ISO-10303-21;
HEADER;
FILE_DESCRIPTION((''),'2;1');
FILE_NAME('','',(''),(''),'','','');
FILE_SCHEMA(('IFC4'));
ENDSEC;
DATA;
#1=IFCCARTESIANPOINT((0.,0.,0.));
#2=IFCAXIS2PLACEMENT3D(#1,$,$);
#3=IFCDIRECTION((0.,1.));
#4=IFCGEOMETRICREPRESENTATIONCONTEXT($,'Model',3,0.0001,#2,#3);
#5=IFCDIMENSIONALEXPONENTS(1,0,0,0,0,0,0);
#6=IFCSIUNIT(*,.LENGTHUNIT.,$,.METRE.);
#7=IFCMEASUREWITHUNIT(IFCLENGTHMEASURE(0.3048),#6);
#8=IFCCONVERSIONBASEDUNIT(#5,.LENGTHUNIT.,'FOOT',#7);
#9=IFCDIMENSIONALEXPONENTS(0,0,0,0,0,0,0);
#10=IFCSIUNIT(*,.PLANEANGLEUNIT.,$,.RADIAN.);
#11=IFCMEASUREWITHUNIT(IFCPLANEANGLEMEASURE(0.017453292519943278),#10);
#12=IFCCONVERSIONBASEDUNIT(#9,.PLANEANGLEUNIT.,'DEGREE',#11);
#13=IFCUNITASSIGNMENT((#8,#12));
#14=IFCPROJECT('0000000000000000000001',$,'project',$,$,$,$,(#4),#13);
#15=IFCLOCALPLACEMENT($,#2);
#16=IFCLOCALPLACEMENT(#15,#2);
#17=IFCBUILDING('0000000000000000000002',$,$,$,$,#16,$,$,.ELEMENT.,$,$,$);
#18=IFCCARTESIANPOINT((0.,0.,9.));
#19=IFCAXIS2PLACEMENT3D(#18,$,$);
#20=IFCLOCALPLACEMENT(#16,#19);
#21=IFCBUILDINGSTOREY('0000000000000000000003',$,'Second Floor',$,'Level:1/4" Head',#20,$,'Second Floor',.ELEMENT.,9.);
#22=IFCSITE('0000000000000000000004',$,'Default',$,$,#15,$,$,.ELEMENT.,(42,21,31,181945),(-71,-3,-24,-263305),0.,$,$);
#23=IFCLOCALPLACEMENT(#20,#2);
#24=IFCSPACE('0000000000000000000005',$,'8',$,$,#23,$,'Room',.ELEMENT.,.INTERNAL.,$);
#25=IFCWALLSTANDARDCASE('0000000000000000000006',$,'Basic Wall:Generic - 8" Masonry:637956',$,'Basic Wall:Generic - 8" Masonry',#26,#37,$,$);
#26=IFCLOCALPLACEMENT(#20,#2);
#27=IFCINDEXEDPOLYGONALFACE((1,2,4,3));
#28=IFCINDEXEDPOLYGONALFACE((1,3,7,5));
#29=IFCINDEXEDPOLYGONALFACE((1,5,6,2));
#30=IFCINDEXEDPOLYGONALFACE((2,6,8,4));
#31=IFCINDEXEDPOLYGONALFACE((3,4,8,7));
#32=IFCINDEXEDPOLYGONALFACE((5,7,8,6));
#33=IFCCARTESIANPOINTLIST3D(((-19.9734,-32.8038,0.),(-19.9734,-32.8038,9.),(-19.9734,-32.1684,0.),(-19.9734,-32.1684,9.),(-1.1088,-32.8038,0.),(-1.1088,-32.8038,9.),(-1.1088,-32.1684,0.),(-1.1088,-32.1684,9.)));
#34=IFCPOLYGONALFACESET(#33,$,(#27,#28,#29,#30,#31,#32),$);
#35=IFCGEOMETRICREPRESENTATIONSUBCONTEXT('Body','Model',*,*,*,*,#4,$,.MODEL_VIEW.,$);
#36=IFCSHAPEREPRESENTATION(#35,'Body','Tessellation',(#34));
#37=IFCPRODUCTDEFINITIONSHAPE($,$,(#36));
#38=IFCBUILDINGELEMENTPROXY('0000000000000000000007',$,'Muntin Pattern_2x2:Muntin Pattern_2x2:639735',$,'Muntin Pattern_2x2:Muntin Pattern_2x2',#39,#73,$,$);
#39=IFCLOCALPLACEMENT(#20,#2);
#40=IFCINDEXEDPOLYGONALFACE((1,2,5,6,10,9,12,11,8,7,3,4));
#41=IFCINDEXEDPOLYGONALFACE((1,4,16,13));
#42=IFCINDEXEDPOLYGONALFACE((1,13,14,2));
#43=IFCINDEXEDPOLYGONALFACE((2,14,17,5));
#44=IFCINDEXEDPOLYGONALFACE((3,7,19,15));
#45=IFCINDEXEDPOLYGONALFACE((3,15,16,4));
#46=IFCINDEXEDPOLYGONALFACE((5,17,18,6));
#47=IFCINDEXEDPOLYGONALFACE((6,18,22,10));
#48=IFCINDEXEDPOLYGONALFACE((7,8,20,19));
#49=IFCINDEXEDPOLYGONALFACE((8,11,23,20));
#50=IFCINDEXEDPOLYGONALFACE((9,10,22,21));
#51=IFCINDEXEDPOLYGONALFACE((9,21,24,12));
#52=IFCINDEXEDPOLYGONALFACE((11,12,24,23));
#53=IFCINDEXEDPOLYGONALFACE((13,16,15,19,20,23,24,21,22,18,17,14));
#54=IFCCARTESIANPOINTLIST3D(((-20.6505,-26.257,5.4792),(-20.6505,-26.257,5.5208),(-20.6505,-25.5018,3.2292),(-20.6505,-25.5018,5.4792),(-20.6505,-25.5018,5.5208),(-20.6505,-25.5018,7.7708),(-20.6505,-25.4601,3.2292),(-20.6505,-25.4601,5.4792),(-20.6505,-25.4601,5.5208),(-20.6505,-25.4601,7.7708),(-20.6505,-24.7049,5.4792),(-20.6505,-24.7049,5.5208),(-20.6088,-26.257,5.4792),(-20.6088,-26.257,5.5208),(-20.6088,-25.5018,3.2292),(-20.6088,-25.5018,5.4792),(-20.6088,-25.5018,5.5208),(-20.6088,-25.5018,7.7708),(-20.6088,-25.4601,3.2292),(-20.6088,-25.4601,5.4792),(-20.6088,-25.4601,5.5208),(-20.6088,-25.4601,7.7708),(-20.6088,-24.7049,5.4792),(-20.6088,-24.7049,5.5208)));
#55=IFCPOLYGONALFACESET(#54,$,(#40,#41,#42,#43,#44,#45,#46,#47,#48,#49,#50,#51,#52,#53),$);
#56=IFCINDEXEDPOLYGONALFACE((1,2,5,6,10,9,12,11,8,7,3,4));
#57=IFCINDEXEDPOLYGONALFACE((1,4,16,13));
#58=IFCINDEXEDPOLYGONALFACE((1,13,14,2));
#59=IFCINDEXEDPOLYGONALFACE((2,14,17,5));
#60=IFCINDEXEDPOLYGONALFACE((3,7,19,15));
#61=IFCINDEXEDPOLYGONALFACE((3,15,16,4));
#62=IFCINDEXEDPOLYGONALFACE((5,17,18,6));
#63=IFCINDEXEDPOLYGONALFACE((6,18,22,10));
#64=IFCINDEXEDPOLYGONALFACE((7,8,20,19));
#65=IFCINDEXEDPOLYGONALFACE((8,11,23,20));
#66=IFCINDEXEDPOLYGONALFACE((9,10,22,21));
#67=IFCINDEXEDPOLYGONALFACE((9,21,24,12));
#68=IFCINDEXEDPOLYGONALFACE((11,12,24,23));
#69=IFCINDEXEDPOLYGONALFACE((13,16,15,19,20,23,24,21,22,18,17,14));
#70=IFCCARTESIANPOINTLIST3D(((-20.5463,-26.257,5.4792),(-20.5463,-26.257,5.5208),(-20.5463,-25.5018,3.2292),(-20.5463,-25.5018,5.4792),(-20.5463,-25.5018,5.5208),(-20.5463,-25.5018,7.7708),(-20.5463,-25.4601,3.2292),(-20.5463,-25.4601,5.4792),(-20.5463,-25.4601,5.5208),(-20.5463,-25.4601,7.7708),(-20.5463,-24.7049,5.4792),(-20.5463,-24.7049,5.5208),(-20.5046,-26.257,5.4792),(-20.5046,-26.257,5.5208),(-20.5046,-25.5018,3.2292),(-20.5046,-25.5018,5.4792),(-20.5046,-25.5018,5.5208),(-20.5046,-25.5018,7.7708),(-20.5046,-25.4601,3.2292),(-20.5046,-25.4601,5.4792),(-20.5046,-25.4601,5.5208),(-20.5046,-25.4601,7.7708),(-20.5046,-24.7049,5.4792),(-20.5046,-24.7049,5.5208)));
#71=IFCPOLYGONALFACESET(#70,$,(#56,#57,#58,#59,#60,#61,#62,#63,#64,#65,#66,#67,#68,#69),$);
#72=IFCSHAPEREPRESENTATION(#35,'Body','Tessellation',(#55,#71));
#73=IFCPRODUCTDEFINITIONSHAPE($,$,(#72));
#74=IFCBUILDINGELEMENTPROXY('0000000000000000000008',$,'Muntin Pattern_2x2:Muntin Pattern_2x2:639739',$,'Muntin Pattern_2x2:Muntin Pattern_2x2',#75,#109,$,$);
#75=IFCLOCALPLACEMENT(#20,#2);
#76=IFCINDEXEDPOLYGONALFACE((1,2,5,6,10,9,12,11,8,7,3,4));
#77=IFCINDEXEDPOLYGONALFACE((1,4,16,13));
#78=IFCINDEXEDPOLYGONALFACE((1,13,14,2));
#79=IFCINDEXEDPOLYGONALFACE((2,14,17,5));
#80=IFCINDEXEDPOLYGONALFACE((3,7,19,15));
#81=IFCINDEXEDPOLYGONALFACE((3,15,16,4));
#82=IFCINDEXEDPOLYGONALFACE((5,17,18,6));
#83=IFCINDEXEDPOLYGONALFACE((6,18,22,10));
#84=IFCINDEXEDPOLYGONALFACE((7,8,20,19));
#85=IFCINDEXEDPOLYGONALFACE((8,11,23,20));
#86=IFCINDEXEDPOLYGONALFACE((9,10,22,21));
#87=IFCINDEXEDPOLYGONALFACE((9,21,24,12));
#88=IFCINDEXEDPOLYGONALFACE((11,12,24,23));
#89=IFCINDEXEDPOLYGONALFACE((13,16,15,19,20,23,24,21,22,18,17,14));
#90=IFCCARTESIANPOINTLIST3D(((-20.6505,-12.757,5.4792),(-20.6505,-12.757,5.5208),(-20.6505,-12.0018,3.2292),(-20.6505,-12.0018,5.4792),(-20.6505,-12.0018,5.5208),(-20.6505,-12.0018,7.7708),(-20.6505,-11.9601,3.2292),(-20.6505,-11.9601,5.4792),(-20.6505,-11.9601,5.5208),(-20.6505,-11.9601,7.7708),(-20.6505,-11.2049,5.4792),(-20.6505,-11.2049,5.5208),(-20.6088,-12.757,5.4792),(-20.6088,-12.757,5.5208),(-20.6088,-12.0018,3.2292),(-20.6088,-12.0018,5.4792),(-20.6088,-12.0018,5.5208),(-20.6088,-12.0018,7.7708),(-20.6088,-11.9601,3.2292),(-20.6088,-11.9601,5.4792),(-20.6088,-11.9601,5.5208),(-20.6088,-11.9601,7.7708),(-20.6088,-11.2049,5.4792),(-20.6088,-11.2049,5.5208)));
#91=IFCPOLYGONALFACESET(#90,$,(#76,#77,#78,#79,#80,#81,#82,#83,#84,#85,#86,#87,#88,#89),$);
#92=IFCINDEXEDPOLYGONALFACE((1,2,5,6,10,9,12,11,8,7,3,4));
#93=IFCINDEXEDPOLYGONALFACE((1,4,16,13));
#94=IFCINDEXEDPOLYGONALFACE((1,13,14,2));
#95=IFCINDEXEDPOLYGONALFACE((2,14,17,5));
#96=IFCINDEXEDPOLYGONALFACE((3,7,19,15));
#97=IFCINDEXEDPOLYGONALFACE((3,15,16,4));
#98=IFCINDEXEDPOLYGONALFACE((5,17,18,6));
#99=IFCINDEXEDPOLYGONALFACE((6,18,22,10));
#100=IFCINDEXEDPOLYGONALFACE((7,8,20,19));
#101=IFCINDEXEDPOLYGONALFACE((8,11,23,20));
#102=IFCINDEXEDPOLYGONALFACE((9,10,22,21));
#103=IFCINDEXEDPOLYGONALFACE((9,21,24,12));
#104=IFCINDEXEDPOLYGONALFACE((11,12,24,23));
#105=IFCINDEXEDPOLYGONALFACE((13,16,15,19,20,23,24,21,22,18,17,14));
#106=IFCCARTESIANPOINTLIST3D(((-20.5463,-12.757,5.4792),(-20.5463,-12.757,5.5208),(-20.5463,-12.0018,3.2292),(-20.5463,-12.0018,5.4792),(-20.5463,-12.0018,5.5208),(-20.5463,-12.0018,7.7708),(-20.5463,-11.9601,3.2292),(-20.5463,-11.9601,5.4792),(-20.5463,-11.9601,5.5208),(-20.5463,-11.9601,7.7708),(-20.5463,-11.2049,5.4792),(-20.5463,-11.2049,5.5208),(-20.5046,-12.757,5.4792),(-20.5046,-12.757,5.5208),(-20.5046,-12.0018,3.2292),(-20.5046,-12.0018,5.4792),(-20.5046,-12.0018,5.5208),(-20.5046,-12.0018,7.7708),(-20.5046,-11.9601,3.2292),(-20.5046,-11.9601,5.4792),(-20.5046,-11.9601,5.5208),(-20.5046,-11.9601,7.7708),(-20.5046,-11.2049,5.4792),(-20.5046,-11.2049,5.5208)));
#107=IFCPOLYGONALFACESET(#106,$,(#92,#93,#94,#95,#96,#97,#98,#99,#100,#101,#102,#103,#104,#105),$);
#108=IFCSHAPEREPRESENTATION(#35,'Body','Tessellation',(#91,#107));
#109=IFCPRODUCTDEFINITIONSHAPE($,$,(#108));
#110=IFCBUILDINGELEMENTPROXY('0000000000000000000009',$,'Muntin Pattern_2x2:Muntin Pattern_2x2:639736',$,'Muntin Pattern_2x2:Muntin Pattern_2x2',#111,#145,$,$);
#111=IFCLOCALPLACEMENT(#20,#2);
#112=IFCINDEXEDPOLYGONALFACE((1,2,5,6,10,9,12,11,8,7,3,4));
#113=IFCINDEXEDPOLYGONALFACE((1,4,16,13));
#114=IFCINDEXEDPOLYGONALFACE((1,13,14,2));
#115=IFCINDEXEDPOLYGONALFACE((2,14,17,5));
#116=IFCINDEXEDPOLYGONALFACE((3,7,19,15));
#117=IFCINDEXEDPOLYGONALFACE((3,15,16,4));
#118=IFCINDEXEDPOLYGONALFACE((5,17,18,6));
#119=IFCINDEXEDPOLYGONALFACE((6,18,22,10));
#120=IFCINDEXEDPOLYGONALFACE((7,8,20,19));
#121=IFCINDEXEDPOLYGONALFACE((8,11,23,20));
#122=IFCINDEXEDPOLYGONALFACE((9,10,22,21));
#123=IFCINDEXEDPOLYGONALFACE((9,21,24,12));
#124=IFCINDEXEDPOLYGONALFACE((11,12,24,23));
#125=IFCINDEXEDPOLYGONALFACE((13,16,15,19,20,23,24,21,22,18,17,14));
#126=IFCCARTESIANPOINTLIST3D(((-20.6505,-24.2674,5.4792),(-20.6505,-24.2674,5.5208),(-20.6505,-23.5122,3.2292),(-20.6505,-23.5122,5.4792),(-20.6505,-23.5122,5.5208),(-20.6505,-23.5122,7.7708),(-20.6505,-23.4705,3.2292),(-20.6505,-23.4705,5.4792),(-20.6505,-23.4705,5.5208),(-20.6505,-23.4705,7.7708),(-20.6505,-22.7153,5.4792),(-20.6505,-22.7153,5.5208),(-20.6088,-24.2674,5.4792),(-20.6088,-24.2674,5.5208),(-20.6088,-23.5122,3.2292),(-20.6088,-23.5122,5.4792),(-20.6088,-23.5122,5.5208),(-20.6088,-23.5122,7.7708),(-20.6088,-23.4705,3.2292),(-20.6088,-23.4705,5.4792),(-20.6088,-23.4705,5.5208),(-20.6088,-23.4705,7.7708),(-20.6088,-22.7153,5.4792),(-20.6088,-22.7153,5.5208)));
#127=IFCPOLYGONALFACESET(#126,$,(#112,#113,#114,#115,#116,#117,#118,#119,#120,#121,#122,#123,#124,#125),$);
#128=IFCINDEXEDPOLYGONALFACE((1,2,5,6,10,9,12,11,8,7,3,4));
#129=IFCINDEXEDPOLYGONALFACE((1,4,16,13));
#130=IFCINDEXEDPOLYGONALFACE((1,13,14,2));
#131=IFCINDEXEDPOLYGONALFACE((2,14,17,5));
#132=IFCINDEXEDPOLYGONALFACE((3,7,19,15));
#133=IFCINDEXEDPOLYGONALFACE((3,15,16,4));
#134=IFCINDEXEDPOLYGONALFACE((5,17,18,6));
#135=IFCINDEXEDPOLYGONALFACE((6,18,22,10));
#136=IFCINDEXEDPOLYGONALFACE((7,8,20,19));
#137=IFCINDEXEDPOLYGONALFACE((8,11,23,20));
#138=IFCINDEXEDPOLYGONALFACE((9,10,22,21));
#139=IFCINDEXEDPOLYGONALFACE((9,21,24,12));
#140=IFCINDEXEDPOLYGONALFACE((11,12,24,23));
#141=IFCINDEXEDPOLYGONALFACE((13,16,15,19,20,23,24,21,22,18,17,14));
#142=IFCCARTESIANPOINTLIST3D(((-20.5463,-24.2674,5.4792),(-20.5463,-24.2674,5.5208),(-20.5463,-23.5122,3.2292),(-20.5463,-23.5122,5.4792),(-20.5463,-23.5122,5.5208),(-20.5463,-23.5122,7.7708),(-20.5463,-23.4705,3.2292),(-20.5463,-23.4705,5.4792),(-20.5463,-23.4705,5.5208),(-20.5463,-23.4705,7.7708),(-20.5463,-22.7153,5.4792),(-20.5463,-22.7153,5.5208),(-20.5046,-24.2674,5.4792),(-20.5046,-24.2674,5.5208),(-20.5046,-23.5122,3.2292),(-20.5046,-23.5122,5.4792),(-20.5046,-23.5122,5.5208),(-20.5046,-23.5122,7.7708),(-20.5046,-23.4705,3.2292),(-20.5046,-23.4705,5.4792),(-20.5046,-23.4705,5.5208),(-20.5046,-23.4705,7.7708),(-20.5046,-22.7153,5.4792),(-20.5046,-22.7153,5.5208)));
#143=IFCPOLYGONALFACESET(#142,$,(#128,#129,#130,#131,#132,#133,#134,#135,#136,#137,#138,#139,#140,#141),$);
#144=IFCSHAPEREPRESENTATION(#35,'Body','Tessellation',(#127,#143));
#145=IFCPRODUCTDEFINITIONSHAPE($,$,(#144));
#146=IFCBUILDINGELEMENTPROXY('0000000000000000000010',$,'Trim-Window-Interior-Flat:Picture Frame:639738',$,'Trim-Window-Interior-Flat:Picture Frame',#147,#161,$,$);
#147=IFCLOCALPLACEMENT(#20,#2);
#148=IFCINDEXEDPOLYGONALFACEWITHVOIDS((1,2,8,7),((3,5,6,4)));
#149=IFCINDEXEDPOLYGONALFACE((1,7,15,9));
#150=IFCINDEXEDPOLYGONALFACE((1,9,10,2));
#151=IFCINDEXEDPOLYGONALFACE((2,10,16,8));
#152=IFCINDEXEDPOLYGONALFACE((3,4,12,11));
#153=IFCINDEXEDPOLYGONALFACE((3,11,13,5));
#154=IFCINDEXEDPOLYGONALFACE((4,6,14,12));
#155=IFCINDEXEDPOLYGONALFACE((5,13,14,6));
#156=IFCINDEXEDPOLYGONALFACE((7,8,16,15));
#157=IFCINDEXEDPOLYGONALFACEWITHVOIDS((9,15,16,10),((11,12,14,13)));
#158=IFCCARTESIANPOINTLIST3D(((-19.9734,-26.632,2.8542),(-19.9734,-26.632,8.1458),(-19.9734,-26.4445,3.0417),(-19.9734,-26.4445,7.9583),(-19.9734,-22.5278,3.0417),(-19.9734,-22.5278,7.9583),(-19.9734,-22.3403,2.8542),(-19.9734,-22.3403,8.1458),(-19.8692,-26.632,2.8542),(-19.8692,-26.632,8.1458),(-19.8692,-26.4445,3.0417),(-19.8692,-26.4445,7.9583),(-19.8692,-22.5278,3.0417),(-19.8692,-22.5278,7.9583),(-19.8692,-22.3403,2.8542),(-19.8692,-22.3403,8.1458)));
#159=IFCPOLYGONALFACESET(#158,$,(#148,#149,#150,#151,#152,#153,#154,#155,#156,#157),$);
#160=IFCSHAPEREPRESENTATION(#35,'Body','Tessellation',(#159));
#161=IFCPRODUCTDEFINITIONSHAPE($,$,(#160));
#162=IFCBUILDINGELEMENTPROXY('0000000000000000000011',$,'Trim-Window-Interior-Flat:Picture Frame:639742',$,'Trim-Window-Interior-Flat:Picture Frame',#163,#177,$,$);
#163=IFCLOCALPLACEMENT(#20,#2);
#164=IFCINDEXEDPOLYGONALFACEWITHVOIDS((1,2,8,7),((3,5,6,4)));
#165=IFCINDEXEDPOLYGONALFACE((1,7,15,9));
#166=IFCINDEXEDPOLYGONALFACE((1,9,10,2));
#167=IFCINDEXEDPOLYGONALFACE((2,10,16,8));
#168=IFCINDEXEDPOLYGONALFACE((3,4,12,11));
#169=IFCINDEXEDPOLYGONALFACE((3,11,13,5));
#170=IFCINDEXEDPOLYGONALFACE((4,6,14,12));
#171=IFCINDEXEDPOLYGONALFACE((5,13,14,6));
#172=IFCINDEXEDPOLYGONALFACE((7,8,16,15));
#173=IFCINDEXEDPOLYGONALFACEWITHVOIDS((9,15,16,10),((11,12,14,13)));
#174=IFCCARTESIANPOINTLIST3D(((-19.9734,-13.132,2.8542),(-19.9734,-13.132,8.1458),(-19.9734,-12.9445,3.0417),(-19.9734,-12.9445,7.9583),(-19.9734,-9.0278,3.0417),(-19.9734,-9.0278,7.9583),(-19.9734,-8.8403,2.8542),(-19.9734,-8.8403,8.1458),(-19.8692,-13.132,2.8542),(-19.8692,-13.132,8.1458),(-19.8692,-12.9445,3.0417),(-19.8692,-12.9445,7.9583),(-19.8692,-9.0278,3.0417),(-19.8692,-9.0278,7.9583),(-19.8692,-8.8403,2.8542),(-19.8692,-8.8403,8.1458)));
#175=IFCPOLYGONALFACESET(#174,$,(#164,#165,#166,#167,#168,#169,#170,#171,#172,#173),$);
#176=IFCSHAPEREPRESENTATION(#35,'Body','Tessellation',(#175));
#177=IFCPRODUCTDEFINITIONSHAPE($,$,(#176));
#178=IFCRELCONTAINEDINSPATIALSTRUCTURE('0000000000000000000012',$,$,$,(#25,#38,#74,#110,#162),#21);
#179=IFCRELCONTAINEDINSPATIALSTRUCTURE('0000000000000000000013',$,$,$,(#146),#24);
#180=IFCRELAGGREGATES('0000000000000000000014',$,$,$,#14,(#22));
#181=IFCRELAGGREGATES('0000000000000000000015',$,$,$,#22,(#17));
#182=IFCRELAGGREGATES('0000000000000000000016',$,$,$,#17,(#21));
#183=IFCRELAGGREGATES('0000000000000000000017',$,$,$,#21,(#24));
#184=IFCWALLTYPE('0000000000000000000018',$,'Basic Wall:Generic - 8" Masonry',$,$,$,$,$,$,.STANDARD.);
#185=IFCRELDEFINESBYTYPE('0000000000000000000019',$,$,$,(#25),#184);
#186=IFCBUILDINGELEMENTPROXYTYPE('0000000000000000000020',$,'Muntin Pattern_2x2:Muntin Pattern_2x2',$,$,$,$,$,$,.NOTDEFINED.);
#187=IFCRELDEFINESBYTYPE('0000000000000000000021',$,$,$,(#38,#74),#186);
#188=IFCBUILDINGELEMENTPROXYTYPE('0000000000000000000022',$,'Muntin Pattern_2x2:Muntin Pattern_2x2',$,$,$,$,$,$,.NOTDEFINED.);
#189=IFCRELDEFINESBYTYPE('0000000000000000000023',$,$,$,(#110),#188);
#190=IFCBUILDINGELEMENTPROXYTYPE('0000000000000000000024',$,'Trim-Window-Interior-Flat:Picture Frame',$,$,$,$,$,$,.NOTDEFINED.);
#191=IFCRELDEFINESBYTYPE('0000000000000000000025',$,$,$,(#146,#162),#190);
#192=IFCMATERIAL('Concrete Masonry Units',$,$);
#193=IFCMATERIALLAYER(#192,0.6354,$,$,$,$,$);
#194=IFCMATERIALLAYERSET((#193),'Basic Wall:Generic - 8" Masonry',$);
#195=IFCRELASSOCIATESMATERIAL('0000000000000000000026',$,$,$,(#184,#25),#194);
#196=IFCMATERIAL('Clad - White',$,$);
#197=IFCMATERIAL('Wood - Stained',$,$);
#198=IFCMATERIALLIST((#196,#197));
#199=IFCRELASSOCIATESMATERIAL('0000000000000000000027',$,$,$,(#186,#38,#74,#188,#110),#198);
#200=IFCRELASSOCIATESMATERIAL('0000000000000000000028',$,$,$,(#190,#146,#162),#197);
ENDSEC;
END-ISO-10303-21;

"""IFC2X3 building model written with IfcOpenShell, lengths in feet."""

from ifc_helpers import new_model, entity, si_unit, converted_unit, direction, frame, frame_2d, origin, place, context, subcontext, project, spatial, polyline, rectangle, outline, extrude, source, transform, mapped, material, material_list, layer, layer_set, layer_usage, type_object, type_shapes, element, save


model = new_model("IFC2X3")

# Units and contexts
model_context = context("Model", 3, precision=0.0001, world=origin(), true_north=direction((0.0, 1.0)))
body_context = subcontext(model_context, "Body", "Model", "MODEL_VIEW")
ifc_project = project(units=[converted_unit("LENGTHUNIT", "FOOT", entity("IfcLengthMeasure", 0.3048), si_unit("LENGTHUNIT", "METRE"), dimensions=[1, 0, 0, 0, 0, 0, 0]), converted_unit("PLANEANGLEUNIT", "DEGREE", entity("IfcPlaneAngleMeasure", 0.017453292519943278), si_unit("PLANEANGLEUNIT", "RADIAN"), dimensions=[0, 0, 0, 0, 0, 0, 0])], contexts=[model_context])

# Site, building, storey
site_placement = place(None, origin())
site = spatial("IfcSite", under=ifc_project, at=site_placement, Name="Default", CompositionType="ELEMENT", RefLatitude=(42, 21, 31, 181945), RefLongitude=(-71, -3, -24, -263305), RefElevation=0.0)
building_placement = place(site_placement, origin())
building = spatial("IfcBuilding", under=site, at=building_placement, CompositionType="ELEMENT")
storey_placement = place(building_placement, frame((0.0, 0.0, 9.0)))
storey = spatial("IfcBuildingStorey", under=building, at=storey_placement, Name="Second Floor", ObjectType="Level:1/4\" Head", LongName="Second Floor", CompositionType="ELEMENT", Elevation=9.0)

# Shared definitions
ifc_material_1 = material(Name="Concrete Masonry Units")
ifc_layer = layer(ifc_material_1, 0.6354)
ifc_layer_set = layer_set([ifc_layer], Name="Basic Wall:Generic - 8\" Masonry")
wall_type = type_object("IfcWallType", Name="Basic Wall:Generic - 8\" Masonry", PredefinedType="STANDARD", material=ifc_layer_set)

# Wall
ifc_layer_usage_1 = layer_usage(ifc_layer_set, "AXIS2", "NEGATIVE", 0.3177)
wall_1_placement = place(storey_placement, frame((-1.1088, -32.4861, 0.0), z_axis=(0.0, 0.0, 1.0), x_axis=(-1.0, 0.0, 0.0)))
element("IfcWallStandardCase", 1, at=wall_1_placement, inside=storey, type_object=wall_type, material=ifc_layer_usage_1, Name="Basic Wall:Generic - 8\" Masonry:637956", ObjectType="Basic Wall:Generic - 8\" Masonry", context=body_context, shape_type="SweptSolid", body=[
    extrude(rectangle(XDim=18.8646, YDim=0.6354, at=frame_2d((9.4323, 0.0), x_axis=(-1.0, 0.0))), origin(), (0.0, 0.0, 1.0), 9.0),
])

# Shared definitions
space_placement = place(storey_placement, origin())
space = spatial("IfcSpace", under=storey, at=space_placement, Name="8", LongName="Room", CompositionType="ELEMENT", InteriorOrExteriorSpace="INTERNAL")

# Building element proxies
ifc_material_2 = material(Name="Clad - White")
ifc_material_3 = material(Name="Wood - Stained")
ifc_material_list_1 = material_list([ifc_material_2, ifc_material_3])
building_element_proxy_type_1 = type_object("IfcBuildingElementProxyType", Name="Muntin Pattern_2x2:Muntin Pattern_2x2", PredefinedType="NOTDEFINED", material=ifc_material_list_1)
shared_shape_1 = source(origin(), body_context, "Body", "SweptSolid", [
    extrude(outline(polyline([(0.0208, -0.0208), (2.2708, -0.0208), (2.2708, 0.0208), (0.0208, 0.0208), (0.0208, 0.776), (-0.0208, 0.776), (-0.0208, 0.0208), (-2.2708, 0.0208), (-2.2708, -0.0208), (-0.0208, -0.0208), (-0.0208, -0.776), (0.0208, -0.776), (0.0208, -0.0208)])), frame((0.0, 0.0313, 2.2708), z_axis=(0.0, 1.0, 0.0), x_axis=(0.0, 0.0, 1.0)), (0.0, 0.0, 1.0), 0.0417),
    extrude(outline(polyline([(0.0208, -0.0208), (2.2708, -0.0208), (2.2708, 0.0208), (0.0208, 0.0208), (0.0208, 0.776), (-0.0208, 0.776), (-0.0208, 0.0208), (-2.2708, 0.0208), (-2.2708, -0.0208), (-0.0208, -0.0208), (-0.0208, -0.776), (0.0208, -0.776), (0.0208, -0.0208)])), frame((0.0, -0.0729, 2.2708), z_axis=(0.0, 1.0, 0.0), x_axis=(0.0, 0.0, 1.0)), (0.0, 0.0, 1.0), 0.0417),
])
type_shapes(building_element_proxy_type_1, [shared_shape_1])
for number, where, z_axis, x_axis, name in (
    (2, (-20.5775, -25.4809, 3.2292), (0.0, 0.0, 1.0), (0.0, 1.0, 0.0), "Muntin Pattern_2x2:Muntin Pattern_2x2:639735"),
    (3, (-20.5775, -11.9809, 3.2292), (0.0, 0.0, 1.0), (0.0, 1.0, 0.0), "Muntin Pattern_2x2:Muntin Pattern_2x2:639739"),
):
    element("IfcBuildingElementProxy", number, at=place(storey_placement, frame(where, z_axis=z_axis, x_axis=x_axis)), inside=storey, type_object=building_element_proxy_type_1, material=ifc_material_list_1, Name=name, ObjectType="Muntin Pattern_2x2:Muntin Pattern_2x2", context=body_context, shape_type="MappedRepresentation", body=[
        mapped(shared_shape_1, transform((0.0, 0.0, 0.0), scale=1.0)),
    ])
building_element_proxy_type_2 = type_object("IfcBuildingElementProxyType", Name="Muntin Pattern_2x2:Muntin Pattern_2x2", PredefinedType="NOTDEFINED", material=ifc_material_list_1)
shared_shape_2 = source(origin(), body_context, "Body", "SweptSolid", [
    extrude(outline(polyline([(0.0208, -0.0208), (2.2708, -0.0208), (2.2708, 0.0208), (0.0208, 0.0208), (0.0208, 0.776), (-0.0208, 0.776), (-0.0208, 0.0208), (-2.2708, 0.0208), (-2.2708, -0.0208), (-0.0208, -0.0208), (-0.0208, -0.776), (0.0208, -0.776), (0.0208, -0.0208)])), frame((0.0, -0.0729, 2.2708), z_axis=(0.0, 1.0, 0.0), x_axis=(0.0, 0.0, 1.0)), (0.0, 0.0, 1.0), 0.0417),
    extrude(outline(polyline([(0.0208, -0.0208), (2.2708, -0.0208), (2.2708, 0.0208), (0.0208, 0.0208), (0.0208, 0.776), (-0.0208, 0.776), (-0.0208, 0.0208), (-2.2708, 0.0208), (-2.2708, -0.0208), (-0.0208, -0.0208), (-0.0208, -0.776), (0.0208, -0.776), (0.0208, -0.0208)])), frame((0.0, 0.0313, 2.2708), z_axis=(0.0, 1.0, 0.0), x_axis=(0.0, 0.0, 1.0)), (0.0, 0.0, 1.0), 0.0417),
])
type_shapes(building_element_proxy_type_2, [shared_shape_2])
proxy_1_placement = place(storey_placement, frame((-20.5775, -23.4913, 3.2292), z_axis=(0.0, 0.0, 1.0), x_axis=(0.0, -1.0, 0.0)))
element("IfcBuildingElementProxy", 4, at=proxy_1_placement, inside=storey, type_object=building_element_proxy_type_2, material=ifc_material_list_1, Name="Muntin Pattern_2x2:Muntin Pattern_2x2:639736", ObjectType="Muntin Pattern_2x2:Muntin Pattern_2x2", context=body_context, shape_type="MappedRepresentation", body=[
    mapped(shared_shape_2, transform((0.0, 0.0, 0.0), scale=1.0)),
])
building_element_proxy_type_3 = type_object("IfcBuildingElementProxyType", Name="Trim-Window-Interior-Flat:Picture Frame", PredefinedType="NOTDEFINED", material=ifc_material_3)
shared_shape_3 = source(origin(), body_context, "Body", "SweptSolid", [
    extrude(outline(polyline([(-2.1458, -2.6458), (2.1458, -2.6458), (2.1458, 2.6458), (-2.1458, 2.6458), (-2.1458, -2.6458)]), holes=[polyline([(-1.9583, -2.4583), (-1.9583, 2.4583), (1.9583, 2.4583), (1.9583, -2.4583), (-1.9583, -2.4583)])]), frame((0.0, -2.5, 0.0), z_axis=(0.0, 0.0, 1.0), x_axis=(-1.0, 0.0, 0.0)), (0.0, 0.0, 1.0), 0.1042),
])
type_shapes(building_element_proxy_type_3, [shared_shape_3])
proxy_2_placement = place(space_placement, frame((-19.9734, -24.4861, 8.0), z_axis=(1.0, 0.0, 0.0), x_axis=(0.0, 1.0, 0.0)))
element("IfcBuildingElementProxy", 5, at=proxy_2_placement, inside=space, type_object=building_element_proxy_type_3, material=ifc_material_3, Name="Trim-Window-Interior-Flat:Picture Frame:639738", ObjectType="Trim-Window-Interior-Flat:Picture Frame", context=body_context, shape_type="MappedRepresentation", body=[
    mapped(shared_shape_3, transform((0.0, 0.0, 0.0), scale=1.0)),
])
proxy_3_placement = place(storey_placement, frame((-19.9734, -10.9861, 8.0), z_axis=(1.0, 0.0, 0.0), x_axis=(0.0, 1.0, 0.0)))
element("IfcBuildingElementProxy", 6, at=proxy_3_placement, inside=storey, type_object=building_element_proxy_type_3, material=ifc_material_3, Name="Trim-Window-Interior-Flat:Picture Frame:639742", ObjectType="Trim-Window-Interior-Flat:Picture Frame", context=body_context, shape_type="MappedRepresentation", body=[
    mapped(shared_shape_3, transform((0.0, 0.0, 0.0), scale=1.0)),
])

save(model, "model.ifc")
